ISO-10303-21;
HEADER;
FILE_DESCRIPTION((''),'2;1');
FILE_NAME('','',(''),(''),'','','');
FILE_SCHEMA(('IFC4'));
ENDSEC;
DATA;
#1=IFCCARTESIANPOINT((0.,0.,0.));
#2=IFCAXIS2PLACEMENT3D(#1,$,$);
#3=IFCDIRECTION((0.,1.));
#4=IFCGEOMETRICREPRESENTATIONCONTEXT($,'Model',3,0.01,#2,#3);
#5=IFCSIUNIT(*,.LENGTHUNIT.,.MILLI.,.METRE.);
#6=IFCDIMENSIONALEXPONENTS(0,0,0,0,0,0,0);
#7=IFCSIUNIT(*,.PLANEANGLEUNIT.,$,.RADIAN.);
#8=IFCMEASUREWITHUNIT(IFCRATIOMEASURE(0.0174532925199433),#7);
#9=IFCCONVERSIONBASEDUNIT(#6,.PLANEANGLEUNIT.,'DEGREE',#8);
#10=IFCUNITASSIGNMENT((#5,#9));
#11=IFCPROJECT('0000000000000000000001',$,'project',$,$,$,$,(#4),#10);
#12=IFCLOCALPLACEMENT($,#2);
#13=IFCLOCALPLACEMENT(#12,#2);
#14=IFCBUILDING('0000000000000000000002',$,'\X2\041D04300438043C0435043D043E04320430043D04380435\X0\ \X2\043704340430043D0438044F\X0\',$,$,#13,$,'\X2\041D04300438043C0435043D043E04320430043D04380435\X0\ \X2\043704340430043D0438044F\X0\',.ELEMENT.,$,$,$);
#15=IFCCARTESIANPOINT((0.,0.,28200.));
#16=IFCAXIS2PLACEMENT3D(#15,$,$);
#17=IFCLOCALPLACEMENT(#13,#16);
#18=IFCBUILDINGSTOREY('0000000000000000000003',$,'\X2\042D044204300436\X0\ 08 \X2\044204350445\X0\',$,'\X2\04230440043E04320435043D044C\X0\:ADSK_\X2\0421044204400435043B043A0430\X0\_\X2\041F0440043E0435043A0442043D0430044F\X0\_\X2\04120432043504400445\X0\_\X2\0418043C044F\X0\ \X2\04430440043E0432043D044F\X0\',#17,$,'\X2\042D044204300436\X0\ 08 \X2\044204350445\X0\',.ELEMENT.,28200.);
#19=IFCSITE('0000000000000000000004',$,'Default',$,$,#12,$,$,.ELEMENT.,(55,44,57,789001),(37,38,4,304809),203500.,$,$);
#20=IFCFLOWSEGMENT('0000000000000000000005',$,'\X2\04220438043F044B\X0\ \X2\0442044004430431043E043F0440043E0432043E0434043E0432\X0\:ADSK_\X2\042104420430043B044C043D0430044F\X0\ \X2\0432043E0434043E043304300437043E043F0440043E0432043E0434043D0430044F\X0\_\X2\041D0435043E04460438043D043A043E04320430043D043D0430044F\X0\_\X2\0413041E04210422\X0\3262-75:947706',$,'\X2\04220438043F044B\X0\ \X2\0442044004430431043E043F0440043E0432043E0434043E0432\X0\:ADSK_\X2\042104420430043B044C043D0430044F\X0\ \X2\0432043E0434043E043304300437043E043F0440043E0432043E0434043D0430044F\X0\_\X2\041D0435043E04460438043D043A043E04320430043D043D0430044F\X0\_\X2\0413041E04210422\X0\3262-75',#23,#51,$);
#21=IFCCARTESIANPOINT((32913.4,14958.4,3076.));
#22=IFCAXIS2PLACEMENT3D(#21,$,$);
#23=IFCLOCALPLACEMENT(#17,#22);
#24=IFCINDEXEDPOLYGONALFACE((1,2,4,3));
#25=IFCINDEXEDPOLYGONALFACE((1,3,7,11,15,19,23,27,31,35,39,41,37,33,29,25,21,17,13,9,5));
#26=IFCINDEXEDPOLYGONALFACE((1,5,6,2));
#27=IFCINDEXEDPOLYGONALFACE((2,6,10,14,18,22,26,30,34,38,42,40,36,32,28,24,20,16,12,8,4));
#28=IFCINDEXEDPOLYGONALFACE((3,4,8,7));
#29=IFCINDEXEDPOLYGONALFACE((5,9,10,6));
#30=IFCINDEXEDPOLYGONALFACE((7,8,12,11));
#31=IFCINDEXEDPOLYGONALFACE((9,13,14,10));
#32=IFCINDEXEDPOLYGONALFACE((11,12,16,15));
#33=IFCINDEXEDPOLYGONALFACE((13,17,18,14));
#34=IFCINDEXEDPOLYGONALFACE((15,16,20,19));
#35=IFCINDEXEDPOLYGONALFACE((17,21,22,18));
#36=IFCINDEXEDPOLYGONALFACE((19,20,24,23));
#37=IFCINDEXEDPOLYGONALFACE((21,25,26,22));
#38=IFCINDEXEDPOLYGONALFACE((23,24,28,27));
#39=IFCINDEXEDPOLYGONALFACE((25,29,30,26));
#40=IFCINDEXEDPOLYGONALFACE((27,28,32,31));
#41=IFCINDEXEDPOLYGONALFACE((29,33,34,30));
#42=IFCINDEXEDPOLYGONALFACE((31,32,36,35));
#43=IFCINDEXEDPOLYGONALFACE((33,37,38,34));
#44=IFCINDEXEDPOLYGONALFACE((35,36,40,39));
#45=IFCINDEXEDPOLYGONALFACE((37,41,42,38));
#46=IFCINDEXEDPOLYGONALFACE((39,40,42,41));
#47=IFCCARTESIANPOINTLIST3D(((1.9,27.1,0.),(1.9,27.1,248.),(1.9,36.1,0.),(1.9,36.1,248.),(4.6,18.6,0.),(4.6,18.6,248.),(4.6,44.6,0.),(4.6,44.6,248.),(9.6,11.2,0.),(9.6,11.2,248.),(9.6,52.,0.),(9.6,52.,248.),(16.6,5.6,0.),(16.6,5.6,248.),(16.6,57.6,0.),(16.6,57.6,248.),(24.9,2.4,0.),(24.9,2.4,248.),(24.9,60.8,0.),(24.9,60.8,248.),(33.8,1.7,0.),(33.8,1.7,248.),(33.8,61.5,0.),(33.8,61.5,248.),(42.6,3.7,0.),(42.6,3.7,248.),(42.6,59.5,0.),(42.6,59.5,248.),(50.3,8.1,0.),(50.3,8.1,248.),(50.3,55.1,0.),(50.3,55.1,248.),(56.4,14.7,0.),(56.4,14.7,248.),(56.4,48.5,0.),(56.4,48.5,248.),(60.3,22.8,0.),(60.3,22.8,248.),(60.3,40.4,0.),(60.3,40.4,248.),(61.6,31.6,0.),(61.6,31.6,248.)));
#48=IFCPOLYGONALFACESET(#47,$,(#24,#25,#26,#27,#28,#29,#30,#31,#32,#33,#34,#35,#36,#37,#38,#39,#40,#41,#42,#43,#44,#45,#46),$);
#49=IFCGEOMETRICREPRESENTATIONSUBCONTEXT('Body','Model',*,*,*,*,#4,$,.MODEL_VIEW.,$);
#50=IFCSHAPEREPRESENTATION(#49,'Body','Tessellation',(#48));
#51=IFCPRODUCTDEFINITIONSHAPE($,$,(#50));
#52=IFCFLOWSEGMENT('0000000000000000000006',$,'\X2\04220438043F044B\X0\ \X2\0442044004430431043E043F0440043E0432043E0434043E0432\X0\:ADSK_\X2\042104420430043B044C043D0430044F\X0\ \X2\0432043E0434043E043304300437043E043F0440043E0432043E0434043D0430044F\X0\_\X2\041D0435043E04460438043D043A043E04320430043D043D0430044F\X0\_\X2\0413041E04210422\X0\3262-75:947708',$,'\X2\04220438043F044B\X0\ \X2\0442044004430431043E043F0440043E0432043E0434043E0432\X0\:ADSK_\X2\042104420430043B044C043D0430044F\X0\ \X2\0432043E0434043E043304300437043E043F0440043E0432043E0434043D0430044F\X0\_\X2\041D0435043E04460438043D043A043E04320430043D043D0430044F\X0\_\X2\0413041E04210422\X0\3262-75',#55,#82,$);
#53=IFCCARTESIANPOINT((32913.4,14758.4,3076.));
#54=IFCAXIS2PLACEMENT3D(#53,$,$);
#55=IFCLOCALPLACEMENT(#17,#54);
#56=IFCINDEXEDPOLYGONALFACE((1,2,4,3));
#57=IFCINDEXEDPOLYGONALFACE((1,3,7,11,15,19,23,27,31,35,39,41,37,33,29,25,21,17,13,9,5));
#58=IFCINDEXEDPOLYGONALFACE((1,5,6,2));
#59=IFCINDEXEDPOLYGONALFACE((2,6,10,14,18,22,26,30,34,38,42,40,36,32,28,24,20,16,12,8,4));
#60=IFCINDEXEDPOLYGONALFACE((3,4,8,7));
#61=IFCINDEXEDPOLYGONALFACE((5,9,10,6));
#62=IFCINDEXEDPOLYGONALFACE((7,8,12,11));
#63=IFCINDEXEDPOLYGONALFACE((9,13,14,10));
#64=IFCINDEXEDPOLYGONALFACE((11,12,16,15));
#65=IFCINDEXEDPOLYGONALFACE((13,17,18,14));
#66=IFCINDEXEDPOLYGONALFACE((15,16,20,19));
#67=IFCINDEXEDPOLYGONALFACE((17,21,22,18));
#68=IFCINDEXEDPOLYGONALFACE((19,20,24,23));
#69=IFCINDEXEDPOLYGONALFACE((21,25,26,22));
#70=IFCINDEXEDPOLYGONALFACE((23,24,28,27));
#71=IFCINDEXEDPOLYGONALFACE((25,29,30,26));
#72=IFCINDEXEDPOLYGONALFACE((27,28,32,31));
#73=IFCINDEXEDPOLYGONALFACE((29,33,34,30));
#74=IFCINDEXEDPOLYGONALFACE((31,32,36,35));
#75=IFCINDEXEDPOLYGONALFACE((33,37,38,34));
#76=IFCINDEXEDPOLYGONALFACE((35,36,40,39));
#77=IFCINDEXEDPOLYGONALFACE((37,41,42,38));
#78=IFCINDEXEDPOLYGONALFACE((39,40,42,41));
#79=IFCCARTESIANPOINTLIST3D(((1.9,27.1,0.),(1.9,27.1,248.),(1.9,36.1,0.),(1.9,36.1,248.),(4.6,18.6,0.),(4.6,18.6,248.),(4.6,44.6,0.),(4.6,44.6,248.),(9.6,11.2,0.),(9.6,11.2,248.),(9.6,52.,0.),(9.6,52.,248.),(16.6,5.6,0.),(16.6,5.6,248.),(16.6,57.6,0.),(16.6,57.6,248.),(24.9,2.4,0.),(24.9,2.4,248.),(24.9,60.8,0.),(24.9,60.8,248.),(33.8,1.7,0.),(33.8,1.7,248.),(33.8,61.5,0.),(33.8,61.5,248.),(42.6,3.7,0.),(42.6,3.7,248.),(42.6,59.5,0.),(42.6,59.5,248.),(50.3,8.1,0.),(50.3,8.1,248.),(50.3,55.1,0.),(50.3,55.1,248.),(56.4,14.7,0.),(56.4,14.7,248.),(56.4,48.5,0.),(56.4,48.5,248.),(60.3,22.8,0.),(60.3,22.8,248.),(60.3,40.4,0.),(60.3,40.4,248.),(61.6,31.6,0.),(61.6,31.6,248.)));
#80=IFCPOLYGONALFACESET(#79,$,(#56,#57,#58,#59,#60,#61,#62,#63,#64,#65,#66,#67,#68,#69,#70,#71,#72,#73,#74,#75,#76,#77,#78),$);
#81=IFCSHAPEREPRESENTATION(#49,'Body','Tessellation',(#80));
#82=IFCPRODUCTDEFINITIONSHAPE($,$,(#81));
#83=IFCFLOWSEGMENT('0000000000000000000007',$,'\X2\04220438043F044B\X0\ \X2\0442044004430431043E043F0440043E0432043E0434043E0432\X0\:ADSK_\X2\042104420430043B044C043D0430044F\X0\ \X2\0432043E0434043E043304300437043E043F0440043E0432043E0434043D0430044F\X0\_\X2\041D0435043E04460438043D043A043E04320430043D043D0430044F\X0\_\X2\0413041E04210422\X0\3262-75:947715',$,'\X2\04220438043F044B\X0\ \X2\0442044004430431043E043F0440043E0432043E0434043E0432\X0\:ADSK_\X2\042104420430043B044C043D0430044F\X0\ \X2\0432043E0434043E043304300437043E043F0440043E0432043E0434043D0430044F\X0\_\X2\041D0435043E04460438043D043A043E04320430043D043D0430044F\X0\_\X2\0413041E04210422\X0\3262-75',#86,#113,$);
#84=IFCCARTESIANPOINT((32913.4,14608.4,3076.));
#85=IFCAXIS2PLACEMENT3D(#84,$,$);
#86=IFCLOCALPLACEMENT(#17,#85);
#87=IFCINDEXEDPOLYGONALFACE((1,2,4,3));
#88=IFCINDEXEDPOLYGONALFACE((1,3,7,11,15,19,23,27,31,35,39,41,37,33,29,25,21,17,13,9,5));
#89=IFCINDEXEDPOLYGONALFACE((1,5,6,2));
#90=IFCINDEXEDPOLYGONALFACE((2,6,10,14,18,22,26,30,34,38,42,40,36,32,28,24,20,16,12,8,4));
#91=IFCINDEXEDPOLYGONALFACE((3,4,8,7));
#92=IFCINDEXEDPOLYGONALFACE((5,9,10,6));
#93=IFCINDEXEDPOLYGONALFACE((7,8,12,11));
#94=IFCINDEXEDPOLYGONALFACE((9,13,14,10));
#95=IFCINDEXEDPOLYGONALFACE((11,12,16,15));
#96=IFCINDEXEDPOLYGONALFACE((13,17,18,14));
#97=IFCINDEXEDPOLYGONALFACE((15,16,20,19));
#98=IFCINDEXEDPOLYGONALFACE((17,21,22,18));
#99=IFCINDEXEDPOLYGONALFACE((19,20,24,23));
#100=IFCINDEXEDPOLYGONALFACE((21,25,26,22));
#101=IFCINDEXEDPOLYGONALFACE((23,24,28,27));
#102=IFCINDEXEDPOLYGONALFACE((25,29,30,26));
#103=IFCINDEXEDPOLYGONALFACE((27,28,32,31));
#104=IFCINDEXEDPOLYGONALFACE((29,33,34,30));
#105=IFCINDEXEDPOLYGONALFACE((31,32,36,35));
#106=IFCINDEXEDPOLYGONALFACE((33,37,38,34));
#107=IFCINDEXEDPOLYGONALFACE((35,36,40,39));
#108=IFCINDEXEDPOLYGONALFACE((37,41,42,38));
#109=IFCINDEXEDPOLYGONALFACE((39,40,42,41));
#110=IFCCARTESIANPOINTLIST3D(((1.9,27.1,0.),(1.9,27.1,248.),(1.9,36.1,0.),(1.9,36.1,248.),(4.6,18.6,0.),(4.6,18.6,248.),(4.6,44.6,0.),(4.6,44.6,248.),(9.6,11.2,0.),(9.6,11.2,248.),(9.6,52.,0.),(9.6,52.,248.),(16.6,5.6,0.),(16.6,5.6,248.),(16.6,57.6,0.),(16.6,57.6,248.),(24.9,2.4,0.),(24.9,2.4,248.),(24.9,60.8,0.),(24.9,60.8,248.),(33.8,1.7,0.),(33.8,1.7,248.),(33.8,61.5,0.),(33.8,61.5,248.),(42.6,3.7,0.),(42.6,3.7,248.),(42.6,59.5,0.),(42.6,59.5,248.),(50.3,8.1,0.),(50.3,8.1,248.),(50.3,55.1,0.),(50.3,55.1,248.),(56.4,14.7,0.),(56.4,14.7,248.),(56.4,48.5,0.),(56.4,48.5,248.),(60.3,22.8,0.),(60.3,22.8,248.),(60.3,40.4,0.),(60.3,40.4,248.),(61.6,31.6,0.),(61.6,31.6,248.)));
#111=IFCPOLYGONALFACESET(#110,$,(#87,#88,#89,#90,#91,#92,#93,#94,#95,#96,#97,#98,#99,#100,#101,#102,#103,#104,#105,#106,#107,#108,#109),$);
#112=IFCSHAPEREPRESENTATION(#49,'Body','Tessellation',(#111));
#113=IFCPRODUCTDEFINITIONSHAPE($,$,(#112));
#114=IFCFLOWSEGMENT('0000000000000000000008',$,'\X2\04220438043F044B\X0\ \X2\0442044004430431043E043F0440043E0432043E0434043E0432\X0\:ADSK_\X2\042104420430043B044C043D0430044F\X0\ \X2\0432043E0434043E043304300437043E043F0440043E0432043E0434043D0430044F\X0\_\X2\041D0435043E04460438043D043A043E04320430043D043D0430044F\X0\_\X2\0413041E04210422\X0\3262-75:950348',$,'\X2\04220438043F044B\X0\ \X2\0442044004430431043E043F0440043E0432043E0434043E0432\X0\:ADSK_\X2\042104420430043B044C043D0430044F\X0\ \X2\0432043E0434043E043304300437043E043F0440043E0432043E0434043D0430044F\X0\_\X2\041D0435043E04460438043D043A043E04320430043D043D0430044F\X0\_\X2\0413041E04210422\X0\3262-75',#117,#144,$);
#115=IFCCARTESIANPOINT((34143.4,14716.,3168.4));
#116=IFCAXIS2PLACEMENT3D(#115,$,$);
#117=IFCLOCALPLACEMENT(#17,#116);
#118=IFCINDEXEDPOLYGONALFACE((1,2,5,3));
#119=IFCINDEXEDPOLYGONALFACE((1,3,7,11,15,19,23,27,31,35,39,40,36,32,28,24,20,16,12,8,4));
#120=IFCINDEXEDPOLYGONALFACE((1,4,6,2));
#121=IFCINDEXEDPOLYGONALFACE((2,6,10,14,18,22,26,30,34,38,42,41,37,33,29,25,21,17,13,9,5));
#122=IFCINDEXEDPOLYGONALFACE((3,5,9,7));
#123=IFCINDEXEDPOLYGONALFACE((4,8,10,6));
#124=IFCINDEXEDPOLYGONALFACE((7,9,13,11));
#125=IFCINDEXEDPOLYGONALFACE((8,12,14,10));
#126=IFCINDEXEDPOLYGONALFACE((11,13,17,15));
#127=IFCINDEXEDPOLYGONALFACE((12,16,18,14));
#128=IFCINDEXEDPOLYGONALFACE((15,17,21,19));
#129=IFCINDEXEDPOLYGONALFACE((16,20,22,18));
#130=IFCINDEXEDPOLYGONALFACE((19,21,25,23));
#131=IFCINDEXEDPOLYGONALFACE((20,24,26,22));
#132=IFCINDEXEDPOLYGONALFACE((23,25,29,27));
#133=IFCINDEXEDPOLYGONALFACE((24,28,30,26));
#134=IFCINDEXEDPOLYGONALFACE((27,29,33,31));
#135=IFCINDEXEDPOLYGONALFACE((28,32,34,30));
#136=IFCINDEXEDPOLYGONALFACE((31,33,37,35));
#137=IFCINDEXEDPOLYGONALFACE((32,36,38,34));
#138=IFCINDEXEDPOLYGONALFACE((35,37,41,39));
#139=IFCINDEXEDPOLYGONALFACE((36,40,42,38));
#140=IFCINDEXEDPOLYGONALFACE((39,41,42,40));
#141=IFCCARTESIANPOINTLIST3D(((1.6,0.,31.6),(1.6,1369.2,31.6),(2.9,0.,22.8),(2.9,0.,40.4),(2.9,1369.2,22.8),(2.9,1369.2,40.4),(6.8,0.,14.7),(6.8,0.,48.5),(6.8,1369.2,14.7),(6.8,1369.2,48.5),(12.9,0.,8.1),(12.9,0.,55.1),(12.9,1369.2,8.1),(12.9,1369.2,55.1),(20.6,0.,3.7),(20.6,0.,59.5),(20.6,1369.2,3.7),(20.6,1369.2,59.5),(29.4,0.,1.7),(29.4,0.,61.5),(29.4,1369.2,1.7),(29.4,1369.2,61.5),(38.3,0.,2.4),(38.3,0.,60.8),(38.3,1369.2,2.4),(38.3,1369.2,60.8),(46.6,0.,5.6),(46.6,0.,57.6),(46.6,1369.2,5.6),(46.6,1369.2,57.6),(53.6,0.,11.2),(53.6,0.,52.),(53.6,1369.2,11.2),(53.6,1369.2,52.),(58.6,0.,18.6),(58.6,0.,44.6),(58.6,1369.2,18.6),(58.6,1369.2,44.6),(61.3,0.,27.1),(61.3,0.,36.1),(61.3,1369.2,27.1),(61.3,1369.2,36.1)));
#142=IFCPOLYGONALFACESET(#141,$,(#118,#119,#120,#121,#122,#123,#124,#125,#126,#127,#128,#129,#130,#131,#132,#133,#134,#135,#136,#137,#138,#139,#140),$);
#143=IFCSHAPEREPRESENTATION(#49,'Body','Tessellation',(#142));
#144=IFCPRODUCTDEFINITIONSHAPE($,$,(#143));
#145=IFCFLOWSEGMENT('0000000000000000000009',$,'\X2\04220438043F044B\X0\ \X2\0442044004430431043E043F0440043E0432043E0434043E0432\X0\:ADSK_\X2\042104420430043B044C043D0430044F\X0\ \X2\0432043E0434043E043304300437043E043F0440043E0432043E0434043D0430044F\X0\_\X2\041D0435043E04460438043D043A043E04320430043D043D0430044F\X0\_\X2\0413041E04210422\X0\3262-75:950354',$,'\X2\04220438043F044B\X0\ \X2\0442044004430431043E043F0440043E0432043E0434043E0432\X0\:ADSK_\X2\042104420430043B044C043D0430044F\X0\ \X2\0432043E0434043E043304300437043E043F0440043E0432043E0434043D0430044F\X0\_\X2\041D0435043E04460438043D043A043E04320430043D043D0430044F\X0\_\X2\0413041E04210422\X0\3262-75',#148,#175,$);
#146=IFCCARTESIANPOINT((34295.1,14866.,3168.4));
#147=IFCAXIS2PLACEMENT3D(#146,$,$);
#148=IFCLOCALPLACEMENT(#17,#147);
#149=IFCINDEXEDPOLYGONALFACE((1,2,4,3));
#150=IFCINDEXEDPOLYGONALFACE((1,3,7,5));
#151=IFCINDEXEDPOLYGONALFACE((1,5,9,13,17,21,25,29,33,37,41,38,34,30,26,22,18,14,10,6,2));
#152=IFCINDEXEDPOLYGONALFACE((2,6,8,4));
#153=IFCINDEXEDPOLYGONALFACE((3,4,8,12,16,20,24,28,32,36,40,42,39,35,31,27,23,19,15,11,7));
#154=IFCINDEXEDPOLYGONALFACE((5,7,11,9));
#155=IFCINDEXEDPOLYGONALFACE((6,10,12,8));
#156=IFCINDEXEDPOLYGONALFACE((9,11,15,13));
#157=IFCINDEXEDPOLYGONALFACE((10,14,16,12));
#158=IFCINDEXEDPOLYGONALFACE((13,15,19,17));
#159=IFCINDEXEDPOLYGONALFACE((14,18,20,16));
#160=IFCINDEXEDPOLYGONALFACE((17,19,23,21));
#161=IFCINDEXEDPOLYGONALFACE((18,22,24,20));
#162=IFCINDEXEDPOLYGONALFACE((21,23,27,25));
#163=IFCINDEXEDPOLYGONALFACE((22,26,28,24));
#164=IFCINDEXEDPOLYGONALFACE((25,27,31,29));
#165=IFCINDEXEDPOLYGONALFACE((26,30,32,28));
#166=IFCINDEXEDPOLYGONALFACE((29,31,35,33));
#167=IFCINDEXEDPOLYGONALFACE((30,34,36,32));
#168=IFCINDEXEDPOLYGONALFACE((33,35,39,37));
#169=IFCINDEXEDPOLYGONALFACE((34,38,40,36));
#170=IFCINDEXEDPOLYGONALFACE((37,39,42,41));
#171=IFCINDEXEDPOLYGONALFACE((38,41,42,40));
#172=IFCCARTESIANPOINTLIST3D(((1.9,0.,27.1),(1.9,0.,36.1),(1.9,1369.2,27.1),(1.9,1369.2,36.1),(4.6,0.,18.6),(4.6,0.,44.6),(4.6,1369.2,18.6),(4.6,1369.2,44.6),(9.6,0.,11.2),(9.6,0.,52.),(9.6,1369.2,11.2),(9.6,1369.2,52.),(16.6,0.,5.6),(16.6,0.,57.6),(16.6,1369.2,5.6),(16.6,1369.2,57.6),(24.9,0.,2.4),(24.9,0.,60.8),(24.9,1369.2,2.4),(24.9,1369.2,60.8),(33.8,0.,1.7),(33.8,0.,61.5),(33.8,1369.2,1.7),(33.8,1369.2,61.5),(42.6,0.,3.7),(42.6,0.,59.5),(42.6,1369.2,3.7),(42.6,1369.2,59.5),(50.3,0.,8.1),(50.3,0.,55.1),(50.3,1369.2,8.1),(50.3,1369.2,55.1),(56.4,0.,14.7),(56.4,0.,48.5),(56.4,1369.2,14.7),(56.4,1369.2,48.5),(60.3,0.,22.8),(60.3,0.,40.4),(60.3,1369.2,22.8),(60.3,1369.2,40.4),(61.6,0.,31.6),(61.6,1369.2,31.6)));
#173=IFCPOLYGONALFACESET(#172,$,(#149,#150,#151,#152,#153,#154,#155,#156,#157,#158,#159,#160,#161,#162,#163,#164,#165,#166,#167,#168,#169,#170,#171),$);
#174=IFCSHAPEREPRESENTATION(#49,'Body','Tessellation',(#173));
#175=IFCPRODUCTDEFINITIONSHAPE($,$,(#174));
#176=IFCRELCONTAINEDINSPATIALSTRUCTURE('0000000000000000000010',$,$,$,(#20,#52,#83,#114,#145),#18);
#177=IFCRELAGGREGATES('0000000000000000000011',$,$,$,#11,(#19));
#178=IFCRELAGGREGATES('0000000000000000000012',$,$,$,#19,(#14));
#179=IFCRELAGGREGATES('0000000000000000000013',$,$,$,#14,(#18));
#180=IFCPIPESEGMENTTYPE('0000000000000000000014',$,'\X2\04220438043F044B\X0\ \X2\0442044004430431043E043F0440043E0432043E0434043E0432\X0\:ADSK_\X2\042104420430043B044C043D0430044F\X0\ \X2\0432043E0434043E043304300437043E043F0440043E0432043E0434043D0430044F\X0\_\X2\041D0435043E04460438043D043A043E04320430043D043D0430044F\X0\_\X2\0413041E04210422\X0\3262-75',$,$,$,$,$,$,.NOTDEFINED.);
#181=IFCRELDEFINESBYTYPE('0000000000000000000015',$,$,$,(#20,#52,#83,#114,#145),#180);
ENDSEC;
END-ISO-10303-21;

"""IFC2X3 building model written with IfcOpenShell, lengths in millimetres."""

from ifc_helpers import new_model, entity, si_unit, converted_unit, direction, frame, origin, origin_2d_with_axis, place, context, subcontext, project, spatial, circle, extrude, type_object, element, save


model = new_model("IFC2X3")

# Units and contexts
model_context = context("Model", 3, precision=0.01, world=origin(), true_north=direction((0.0, 1.0)))
body_context = subcontext(model_context, "Body", "Model", "MODEL_VIEW")
ifc_project = project(units=[si_unit("LENGTHUNIT", "METRE", prefix="MILLI"), converted_unit("PLANEANGLEUNIT", "DEGREE", entity("IfcRatioMeasure", 0.0174532925199433), si_unit("PLANEANGLEUNIT", "RADIAN"), dimensions=[0, 0, 0, 0, 0, 0, 0])], contexts=[model_context])

# Site, building, storey
site_placement = place(None, origin())
site = spatial("IfcSite", under=ifc_project, at=site_placement, Name="Default", CompositionType="ELEMENT", RefLatitude=(55, 44, 57, 789001), RefLongitude=(37, 38, 4, 304809), RefElevation=203500.0)
building_placement = place(site_placement, origin())
building = spatial("IfcBuilding", under=site, at=building_placement, Name="Наименование здания", LongName="Наименование здания", CompositionType="ELEMENT")
storey_placement = place(building_placement, frame((0.0, 0.0, 28200.0)))
storey = spatial("IfcBuildingStorey", under=building, at=storey_placement, Name="Этаж 08 тех", ObjectType="Уровень:ADSK_Стрелка_Проектная_Вверх_Имя уровня", LongName="Этаж 08 тех", CompositionType="ELEMENT", Elevation=28200.0)

# Flow segments
pipe_segment_type = type_object("IfcPipeSegmentType", Name="Типы трубопроводов:ADSK_Стальная водогазопроводная_Неоцинкованная_ГОСТ3262-75", PredefinedType="NOTDEFINED")
for number, where, name in (
    (1, (32913.4, 14958.4, 3076.0), "Типы трубопроводов:ADSK_Стальная водогазопроводная_Неоцинкованная_ГОСТ3262-75:947706"),
    (2, (32913.4, 14758.4, 3076.0), "Типы трубопроводов:ADSK_Стальная водогазопроводная_Неоцинкованная_ГОСТ3262-75:947708"),
):
    element("IfcFlowSegment", number, at=place(storey_placement, frame(where)), inside=storey, type_object=pipe_segment_type, Name=name, ObjectType="Типы трубопроводов:ADSK_Стальная водогазопроводная_Неоцинкованная_ГОСТ3262-75", context=body_context, shape_type="SweptSolid", body=[
        extrude(circle(Radius=30.0, at=origin_2d_with_axis()), frame((31.6, 31.6, 0.0)), (0.0, 0.0, 1.0), 248.0),
    ])
flow_segment_1_placement = place(storey_placement, frame((32913.4, 14608.4, 3076.0)))
element("IfcFlowSegment", 3, at=flow_segment_1_placement, inside=storey, type_object=pipe_segment_type, Name="Типы трубопроводов:ADSK_Стальная водогазопроводная_Неоцинкованная_ГОСТ3262-75:947715", ObjectType="Типы трубопроводов:ADSK_Стальная водогазопроводная_Неоцинкованная_ГОСТ3262-75", context=body_context, shape_type="SweptSolid", body=[
    extrude(circle(Radius=30.0, at=origin_2d_with_axis()), frame((31.6, 31.6, 0.0)), (0.0, 0.0, 1.0), 248.0),
])
flow_segment_2_placement = place(storey_placement, frame((34143.4, 14716.0, 3168.4)))
element("IfcFlowSegment", 4, at=flow_segment_2_placement, inside=storey, type_object=pipe_segment_type, Name="Типы трубопроводов:ADSK_Стальная водогазопроводная_Неоцинкованная_ГОСТ3262-75:950348", ObjectType="Типы трубопроводов:ADSK_Стальная водогазопроводная_Неоцинкованная_ГОСТ3262-75", context=body_context, shape_type="SweptSolid", body=[
    extrude(circle(Radius=30.0, at=origin_2d_with_axis()), frame((31.6, 0.0, 31.6), z_axis=(0.0, 1.0, 0.0), x_axis=(-1.0, 0.0, 0.0)), (0.0, 0.0, 1.0), 1369.2),
])
flow_segment_3_placement = place(storey_placement, frame((34295.1, 14866.0, 3168.4)))
element("IfcFlowSegment", 5, at=flow_segment_3_placement, inside=storey, type_object=pipe_segment_type, Name="Типы трубопроводов:ADSK_Стальная водогазопроводная_Неоцинкованная_ГОСТ3262-75:950354", ObjectType="Типы трубопроводов:ADSK_Стальная водогазопроводная_Неоцинкованная_ГОСТ3262-75", context=body_context, shape_type="SweptSolid", body=[
    extrude(circle(Radius=30.0, at=origin_2d_with_axis()), frame((31.6, 0.0, 31.6), z_axis=(0.0, 1.0, 0.0), x_axis=(1.0, 0.0, 0.0)), (0.0, 0.0, 1.0), 1369.2),
])

save(model, "model.ifc")
